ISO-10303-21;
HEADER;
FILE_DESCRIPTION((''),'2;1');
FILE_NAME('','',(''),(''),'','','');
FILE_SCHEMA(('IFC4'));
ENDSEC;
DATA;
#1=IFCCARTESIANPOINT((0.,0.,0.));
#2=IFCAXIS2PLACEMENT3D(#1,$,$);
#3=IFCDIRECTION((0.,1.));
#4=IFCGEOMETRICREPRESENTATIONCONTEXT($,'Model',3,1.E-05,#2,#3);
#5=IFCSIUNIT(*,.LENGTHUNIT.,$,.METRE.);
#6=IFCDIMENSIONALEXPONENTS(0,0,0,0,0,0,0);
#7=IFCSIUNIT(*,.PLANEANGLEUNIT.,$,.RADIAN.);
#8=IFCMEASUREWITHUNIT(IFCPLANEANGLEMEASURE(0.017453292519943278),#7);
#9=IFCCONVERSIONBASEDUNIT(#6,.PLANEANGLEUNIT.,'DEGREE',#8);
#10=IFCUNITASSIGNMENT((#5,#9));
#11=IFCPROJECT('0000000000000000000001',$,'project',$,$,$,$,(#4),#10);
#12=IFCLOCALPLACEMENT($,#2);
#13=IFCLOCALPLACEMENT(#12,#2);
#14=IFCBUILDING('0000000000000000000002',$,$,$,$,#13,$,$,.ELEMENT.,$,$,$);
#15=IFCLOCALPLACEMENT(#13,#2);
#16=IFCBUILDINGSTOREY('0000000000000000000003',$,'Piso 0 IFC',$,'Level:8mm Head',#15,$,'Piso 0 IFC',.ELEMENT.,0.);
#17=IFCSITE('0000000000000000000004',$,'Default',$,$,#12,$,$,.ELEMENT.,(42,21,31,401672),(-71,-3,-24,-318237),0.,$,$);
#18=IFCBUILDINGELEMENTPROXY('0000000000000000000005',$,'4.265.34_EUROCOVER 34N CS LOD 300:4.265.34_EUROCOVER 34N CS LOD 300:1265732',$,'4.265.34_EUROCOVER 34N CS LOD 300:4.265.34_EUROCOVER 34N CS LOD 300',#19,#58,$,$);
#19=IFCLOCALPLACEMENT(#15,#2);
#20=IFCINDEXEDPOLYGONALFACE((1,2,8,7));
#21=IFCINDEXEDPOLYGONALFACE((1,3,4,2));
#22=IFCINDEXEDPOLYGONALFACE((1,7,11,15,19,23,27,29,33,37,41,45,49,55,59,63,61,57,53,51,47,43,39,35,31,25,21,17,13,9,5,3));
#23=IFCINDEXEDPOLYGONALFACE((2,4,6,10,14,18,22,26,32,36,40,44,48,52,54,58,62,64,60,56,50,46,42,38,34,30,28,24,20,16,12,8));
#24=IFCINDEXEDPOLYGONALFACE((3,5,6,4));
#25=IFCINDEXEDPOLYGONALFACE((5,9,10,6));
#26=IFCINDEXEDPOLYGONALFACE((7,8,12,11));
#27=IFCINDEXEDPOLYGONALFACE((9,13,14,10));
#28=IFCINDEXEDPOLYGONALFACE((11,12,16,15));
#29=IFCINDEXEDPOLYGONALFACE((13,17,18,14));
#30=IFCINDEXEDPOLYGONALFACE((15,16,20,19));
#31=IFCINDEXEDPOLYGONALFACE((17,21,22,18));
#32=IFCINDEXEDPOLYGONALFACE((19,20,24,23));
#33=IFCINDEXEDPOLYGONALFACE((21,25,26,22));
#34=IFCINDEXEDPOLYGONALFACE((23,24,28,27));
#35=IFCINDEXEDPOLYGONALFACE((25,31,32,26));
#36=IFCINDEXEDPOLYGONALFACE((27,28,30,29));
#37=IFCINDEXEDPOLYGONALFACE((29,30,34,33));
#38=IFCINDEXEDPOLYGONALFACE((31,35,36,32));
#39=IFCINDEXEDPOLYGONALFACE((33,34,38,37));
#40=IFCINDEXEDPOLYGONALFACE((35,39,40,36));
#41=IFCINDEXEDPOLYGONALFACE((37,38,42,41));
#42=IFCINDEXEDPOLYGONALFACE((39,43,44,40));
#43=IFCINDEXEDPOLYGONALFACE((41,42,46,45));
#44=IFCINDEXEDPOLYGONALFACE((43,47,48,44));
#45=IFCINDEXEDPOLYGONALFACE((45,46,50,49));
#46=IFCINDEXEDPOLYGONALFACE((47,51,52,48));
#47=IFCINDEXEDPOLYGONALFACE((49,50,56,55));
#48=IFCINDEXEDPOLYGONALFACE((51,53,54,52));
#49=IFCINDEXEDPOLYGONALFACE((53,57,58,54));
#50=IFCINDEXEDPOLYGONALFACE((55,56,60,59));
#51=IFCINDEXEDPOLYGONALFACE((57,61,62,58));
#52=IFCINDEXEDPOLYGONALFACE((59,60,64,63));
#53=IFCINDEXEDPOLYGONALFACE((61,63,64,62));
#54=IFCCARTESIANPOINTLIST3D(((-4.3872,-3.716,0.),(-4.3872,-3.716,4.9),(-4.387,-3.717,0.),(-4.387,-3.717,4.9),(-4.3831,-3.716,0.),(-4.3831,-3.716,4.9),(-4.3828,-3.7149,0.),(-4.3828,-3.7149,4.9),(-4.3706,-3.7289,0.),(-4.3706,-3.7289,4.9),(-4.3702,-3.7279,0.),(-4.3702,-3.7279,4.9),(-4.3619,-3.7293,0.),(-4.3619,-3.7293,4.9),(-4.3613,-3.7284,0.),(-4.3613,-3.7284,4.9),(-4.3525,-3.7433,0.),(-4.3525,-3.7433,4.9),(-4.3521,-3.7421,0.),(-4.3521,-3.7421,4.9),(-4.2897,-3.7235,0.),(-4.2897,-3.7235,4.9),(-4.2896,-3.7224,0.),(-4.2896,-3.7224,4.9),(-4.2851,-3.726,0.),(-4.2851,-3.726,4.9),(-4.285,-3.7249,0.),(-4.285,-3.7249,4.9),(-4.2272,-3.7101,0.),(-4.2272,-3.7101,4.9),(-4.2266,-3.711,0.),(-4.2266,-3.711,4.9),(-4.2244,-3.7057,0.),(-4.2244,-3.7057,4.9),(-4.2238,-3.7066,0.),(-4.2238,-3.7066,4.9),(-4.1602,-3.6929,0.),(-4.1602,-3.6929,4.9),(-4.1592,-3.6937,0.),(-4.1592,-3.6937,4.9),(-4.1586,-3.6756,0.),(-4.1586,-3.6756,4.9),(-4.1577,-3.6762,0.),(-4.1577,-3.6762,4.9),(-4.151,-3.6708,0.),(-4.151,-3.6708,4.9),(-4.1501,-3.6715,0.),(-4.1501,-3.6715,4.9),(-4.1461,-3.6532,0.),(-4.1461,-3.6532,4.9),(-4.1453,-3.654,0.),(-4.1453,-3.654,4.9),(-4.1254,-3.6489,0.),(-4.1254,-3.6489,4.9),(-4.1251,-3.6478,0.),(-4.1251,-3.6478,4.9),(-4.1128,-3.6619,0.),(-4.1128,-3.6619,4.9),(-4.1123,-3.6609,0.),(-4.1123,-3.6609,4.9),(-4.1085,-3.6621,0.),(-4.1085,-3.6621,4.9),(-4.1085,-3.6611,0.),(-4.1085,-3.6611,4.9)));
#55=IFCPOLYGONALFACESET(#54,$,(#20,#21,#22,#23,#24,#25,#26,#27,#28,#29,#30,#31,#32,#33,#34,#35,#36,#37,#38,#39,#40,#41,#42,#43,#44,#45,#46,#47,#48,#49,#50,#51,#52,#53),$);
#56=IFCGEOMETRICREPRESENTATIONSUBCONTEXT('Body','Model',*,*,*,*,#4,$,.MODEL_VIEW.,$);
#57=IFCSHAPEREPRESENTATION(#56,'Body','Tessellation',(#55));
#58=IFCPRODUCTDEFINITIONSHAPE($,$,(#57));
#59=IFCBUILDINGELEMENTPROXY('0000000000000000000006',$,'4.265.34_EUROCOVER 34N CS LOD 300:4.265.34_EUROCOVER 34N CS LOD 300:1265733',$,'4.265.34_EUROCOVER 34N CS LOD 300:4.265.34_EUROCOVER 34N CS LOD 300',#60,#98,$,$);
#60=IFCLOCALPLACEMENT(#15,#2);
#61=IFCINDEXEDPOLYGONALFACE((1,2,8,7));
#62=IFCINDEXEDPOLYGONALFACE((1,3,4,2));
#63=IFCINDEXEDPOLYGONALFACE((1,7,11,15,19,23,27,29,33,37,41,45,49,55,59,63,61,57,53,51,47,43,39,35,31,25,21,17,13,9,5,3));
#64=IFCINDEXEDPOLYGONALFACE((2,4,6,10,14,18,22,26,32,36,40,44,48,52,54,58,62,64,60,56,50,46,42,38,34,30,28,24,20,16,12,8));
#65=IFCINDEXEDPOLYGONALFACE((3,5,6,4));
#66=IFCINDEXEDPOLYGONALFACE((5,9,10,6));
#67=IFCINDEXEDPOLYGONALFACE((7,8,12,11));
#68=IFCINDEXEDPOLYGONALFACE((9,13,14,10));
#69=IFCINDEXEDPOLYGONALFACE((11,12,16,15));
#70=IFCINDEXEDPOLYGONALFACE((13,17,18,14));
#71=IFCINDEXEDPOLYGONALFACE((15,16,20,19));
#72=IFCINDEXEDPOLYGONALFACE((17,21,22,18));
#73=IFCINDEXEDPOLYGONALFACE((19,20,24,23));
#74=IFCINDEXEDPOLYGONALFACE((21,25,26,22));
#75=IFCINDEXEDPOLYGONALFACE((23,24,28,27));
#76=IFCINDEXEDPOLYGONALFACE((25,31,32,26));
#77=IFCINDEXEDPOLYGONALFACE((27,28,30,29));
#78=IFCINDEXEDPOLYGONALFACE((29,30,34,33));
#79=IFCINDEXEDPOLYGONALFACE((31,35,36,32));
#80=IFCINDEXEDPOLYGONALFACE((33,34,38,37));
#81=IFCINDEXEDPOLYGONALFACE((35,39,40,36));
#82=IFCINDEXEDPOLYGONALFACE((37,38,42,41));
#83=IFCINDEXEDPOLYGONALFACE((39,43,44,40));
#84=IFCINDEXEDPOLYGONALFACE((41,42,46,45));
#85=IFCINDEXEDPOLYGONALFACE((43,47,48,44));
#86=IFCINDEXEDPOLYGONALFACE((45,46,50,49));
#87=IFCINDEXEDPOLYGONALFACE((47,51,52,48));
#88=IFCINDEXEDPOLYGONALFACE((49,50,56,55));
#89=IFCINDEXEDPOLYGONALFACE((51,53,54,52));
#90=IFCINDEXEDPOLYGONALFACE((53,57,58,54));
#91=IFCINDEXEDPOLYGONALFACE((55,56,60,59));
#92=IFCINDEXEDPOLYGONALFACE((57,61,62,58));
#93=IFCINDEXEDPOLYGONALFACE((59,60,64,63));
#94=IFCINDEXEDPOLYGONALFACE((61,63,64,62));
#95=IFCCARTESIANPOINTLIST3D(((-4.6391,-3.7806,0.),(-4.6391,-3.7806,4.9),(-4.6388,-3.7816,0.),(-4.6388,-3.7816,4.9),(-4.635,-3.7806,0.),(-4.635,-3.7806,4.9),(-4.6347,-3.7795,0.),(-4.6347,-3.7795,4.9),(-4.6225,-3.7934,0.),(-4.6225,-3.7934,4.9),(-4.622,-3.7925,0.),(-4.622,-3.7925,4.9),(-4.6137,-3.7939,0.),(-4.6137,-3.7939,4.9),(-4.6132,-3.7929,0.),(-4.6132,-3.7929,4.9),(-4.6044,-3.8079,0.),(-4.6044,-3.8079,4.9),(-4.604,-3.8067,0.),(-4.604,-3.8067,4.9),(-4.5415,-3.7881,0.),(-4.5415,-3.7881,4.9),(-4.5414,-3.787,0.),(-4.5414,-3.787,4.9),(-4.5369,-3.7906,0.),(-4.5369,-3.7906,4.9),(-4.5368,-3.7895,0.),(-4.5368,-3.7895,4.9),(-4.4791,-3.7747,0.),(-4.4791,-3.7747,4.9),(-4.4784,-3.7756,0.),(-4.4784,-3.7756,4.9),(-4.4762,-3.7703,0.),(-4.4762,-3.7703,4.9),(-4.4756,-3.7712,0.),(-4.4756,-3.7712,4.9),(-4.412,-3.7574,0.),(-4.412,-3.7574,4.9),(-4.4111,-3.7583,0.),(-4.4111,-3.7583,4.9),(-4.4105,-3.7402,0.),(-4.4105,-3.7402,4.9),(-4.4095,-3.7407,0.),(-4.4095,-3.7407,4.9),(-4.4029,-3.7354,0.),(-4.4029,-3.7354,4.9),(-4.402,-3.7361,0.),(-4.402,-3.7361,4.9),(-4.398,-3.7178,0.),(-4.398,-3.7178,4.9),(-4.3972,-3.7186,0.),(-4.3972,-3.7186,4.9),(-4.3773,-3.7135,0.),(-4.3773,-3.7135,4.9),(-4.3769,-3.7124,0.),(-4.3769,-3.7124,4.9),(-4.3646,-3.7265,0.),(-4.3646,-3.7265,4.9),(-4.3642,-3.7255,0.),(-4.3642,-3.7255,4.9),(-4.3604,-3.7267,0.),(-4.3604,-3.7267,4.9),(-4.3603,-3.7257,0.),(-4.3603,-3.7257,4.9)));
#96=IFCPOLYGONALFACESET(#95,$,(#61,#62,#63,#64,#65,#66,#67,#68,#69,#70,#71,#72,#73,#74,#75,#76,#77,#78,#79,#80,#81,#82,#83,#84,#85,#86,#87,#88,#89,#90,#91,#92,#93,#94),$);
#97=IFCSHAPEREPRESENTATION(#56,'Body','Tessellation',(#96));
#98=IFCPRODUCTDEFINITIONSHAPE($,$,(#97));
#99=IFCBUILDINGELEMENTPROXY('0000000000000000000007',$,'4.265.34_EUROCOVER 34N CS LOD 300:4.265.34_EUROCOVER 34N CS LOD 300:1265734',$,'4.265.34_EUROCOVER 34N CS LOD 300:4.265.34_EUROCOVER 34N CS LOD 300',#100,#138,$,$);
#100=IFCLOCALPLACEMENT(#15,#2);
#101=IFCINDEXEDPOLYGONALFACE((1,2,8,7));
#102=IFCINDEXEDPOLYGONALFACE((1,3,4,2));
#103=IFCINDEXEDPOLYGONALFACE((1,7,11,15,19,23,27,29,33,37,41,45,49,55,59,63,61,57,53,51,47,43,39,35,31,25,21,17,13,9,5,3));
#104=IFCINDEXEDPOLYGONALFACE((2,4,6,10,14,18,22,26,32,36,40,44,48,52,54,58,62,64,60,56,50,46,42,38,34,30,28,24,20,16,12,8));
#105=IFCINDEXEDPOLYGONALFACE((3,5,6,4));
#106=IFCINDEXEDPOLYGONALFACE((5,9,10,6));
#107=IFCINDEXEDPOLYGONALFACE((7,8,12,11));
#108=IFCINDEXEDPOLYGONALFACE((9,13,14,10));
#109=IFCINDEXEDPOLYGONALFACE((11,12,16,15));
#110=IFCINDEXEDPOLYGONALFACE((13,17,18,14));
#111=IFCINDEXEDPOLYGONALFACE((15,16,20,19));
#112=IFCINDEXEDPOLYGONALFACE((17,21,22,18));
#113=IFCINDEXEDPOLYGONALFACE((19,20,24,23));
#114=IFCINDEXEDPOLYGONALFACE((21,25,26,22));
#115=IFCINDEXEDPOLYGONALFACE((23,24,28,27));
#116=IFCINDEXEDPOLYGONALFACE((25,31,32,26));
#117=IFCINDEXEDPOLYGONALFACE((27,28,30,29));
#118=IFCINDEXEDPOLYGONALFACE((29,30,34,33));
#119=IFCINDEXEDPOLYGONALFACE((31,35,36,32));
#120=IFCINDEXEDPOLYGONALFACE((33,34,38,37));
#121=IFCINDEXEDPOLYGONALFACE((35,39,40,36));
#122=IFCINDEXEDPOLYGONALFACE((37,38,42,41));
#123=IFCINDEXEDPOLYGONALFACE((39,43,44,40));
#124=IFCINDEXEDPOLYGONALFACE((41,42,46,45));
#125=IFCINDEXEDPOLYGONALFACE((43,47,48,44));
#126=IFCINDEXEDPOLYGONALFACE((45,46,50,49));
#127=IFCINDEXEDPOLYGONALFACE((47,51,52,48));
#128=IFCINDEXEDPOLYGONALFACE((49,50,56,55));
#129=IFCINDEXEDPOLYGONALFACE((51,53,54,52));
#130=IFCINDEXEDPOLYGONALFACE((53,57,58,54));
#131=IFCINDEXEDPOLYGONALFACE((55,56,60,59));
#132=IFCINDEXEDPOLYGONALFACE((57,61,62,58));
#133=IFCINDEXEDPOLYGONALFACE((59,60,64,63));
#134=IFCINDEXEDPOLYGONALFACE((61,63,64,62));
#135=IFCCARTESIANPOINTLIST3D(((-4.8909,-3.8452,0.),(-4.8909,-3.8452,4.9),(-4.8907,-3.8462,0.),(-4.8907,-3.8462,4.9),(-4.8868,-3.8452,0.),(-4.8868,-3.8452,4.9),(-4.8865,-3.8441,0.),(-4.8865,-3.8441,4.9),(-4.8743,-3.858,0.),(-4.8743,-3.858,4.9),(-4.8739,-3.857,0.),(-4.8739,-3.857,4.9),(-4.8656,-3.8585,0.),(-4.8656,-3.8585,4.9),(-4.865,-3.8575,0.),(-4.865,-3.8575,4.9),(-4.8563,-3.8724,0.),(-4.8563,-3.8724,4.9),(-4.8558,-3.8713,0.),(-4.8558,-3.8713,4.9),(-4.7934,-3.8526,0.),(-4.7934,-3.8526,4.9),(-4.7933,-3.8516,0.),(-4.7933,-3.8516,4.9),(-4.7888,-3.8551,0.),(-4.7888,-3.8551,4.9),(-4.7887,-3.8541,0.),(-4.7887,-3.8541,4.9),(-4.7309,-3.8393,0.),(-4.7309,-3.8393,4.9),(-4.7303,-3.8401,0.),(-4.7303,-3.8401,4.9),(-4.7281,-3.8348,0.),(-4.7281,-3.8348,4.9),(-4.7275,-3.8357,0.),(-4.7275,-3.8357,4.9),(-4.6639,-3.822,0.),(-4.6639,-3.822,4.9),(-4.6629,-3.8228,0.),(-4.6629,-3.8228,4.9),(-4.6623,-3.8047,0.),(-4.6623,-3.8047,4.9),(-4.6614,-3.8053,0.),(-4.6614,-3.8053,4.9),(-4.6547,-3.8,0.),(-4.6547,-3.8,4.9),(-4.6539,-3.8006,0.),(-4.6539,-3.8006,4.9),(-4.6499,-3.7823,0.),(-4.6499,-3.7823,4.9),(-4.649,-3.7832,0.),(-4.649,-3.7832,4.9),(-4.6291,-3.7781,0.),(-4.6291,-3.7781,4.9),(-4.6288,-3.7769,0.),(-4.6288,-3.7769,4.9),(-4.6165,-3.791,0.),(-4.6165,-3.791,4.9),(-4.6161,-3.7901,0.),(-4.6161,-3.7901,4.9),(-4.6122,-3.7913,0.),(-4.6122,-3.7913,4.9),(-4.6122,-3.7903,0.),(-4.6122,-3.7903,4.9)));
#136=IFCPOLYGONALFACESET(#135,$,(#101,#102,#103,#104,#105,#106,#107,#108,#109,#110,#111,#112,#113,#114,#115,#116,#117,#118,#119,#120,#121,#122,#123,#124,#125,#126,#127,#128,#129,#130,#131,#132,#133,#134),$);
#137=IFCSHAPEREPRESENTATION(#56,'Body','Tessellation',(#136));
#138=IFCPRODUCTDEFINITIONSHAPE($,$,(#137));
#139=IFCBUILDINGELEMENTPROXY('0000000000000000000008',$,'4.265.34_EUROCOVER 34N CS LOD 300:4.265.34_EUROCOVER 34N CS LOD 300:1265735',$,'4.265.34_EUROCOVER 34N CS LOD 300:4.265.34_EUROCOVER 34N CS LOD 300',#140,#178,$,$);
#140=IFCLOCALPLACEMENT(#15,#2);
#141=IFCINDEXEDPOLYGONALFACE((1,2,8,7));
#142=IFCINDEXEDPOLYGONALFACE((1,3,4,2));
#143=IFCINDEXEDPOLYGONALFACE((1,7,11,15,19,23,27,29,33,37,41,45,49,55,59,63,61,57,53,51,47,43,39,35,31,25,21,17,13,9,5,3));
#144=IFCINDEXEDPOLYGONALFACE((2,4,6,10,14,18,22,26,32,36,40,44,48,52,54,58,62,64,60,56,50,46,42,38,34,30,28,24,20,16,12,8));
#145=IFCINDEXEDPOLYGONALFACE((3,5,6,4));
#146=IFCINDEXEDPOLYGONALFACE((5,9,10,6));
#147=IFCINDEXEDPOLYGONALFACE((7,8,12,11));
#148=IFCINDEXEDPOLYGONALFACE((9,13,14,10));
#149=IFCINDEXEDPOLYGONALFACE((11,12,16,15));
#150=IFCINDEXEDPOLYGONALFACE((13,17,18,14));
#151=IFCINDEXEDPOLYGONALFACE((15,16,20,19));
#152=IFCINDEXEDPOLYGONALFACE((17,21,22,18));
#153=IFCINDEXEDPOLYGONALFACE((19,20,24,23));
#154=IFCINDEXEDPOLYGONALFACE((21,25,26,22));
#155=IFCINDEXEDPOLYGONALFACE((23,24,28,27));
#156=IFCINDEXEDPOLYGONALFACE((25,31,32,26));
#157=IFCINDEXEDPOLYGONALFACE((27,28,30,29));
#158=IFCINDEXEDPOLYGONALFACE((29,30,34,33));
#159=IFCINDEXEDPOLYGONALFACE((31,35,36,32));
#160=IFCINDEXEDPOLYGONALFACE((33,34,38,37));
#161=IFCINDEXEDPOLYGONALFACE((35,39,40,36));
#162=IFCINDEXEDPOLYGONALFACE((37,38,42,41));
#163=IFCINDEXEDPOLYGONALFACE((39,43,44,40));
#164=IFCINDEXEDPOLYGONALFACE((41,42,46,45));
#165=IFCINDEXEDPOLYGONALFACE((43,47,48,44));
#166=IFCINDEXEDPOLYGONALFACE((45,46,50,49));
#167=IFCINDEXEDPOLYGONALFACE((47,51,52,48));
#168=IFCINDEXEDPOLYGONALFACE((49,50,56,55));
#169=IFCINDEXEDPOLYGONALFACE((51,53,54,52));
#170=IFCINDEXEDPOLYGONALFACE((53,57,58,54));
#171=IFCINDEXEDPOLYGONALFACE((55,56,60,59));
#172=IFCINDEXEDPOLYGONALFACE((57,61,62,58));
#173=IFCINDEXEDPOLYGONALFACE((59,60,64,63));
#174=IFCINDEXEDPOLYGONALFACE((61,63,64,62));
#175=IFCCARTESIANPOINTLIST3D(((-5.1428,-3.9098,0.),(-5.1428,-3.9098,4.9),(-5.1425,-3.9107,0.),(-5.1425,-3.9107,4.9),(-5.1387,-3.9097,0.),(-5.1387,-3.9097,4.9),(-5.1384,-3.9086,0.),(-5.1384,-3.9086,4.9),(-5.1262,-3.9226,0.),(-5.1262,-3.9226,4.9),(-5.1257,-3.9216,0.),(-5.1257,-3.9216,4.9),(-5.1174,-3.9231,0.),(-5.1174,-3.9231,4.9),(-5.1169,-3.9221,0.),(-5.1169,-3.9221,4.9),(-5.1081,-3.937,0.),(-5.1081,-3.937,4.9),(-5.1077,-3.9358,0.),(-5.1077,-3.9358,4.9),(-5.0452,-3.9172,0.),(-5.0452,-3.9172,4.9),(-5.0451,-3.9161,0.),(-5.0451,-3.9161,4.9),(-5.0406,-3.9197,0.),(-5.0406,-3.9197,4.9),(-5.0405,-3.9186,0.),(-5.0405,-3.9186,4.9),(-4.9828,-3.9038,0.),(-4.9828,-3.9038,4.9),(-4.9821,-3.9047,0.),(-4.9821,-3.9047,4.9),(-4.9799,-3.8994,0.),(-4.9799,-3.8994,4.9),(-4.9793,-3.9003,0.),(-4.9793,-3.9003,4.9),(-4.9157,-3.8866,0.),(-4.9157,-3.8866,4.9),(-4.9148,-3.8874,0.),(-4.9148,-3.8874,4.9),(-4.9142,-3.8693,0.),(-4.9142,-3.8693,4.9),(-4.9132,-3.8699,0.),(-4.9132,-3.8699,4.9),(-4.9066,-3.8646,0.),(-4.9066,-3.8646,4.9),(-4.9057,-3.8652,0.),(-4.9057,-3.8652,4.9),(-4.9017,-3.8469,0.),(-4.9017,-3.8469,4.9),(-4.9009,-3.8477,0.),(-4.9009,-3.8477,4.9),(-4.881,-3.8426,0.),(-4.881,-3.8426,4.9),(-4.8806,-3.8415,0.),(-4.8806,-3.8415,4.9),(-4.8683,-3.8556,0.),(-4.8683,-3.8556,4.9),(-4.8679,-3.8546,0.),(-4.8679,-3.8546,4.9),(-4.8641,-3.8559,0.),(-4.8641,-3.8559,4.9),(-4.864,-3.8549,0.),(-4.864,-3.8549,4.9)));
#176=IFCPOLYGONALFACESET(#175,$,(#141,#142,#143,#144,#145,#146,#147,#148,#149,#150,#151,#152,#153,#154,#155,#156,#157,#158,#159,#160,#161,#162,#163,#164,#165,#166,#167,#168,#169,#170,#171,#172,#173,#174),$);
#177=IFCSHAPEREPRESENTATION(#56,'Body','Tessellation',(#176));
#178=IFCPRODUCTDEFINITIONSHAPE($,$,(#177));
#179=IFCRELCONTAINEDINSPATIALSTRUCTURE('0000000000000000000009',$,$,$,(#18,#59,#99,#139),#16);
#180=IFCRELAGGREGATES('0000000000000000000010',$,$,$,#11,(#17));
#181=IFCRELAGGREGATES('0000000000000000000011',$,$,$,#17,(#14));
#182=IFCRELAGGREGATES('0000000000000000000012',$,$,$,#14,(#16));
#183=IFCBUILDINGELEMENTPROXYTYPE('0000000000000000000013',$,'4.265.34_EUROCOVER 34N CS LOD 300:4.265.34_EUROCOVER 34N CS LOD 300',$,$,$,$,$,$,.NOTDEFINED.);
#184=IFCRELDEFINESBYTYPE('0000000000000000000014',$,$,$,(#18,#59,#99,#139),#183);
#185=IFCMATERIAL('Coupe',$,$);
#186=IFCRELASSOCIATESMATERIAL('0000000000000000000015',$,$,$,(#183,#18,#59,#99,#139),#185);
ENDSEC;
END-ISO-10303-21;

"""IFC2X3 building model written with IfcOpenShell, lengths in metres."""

from ifc_helpers import new_model, entity, si_unit, converted_unit, direction, frame, origin, place, context, subcontext, project, spatial, polyline, outline, extrude, source, transform, mapped, material, type_object, type_shapes, element, save


model = new_model("IFC2X3")

# Units and contexts
model_context = context("Model", 3, precision=1e-05, world=origin(), true_north=direction((0.0, 1.0)))
body_context = subcontext(model_context, "Body", "Model", "MODEL_VIEW")
ifc_project = project(units=[si_unit("LENGTHUNIT", "METRE"), converted_unit("PLANEANGLEUNIT", "DEGREE", entity("IfcPlaneAngleMeasure", 0.017453292519943278), si_unit("PLANEANGLEUNIT", "RADIAN"), dimensions=[0, 0, 0, 0, 0, 0, 0])], contexts=[model_context])

# Site, building, storey
site_placement = place(None, origin())
site = spatial("IfcSite", under=ifc_project, at=site_placement, Name="Default", CompositionType="ELEMENT", RefLatitude=(42, 21, 31, 401672), RefLongitude=(-71, -3, -24, -318237), RefElevation=0.0)
building_placement = place(site_placement, origin())
building = spatial("IfcBuilding", under=site, at=building_placement, CompositionType="ELEMENT")
storey_placement = place(building_placement, origin())
storey = spatial("IfcBuildingStorey", under=building, at=storey_placement, Name="Piso 0 IFC", ObjectType="Level:8mm Head", LongName="Piso 0 IFC", CompositionType="ELEMENT", Elevation=0.0)

# Building element proxies
ifc_material_1 = material(Name="Coupe")
building_element_proxy_type = type_object("IfcBuildingElementProxyType", Name="4.265.34_EUROCOVER 34N CS LOD 300:4.265.34_EUROCOVER 34N CS LOD 300", PredefinedType="NOTDEFINED", material=ifc_material_1)
shared_shape_1 = source(origin(), body_context, "Body", "SweptSolid", [
    extrude(outline(polyline([(0.0449, 0.1162), (0.063, 0.1162), (0.0661, 0.1191), (0.0654, 0.1198), (0.0626, 0.1172), (0.0443, 0.1172), (0.0335, 0.0983), (0.0428, 0.0826), (0.0409, 0.0738), (0.0522, 0.0606), (0.0167, 0.0056), (0.0179, 0.0005), (-0.0117, -0.0512), (-0.0167, -0.0528), (-0.0462, -0.1114), (-0.0624, -0.1084), (-0.069, -0.1145), (-0.0871, -0.1145), (-0.0893, -0.1184), (-0.0885, -0.1189), (-0.0865, -0.1155), (-0.0686, -0.1155), (-0.0621, -0.1095), (-0.0456, -0.1125), (-0.016, -0.0536), (-0.0111, -0.0521), (0.0189, 0.0004), (0.0177, 0.0054), (0.0535, 0.0607), (0.0419, 0.074), (0.0438, 0.0827), (0.0347, 0.0983), (0.0449, 0.1162)])), frame((-0.0171, -0.0163, 0.0), z_axis=(0.0, 0.0, 1.0), x_axis=(-0.496574, 0.867994, 0.0)), (0.0, 0.0, 1.0), 4.9),
])
type_shapes(building_element_proxy_type, [shared_shape_1])
for number, where, z_axis, x_axis, name in (
    (1, (-4.2526, -3.7177, 0.0), (0.0, 0.0, 1.0), (-0.968666, -0.248367, 0.0), "4.265.34_EUROCOVER 34N CS LOD 300:4.265.34_EUROCOVER 34N CS LOD 300:1265732"),
    (2, (-4.5045, -3.7822, 0.0), (0.0, 0.0, 1.0), (-0.968666, -0.248367, 0.0), "4.265.34_EUROCOVER 34N CS LOD 300:4.265.34_EUROCOVER 34N CS LOD 300:1265733"),
    (3, (-4.7563, -3.8468, 0.0), (0.0, 0.0, 1.0), (-0.968666, -0.248367, 0.0), "4.265.34_EUROCOVER 34N CS LOD 300:4.265.34_EUROCOVER 34N CS LOD 300:1265734"),
    (4, (-5.0082, -3.9114, 0.0), (0.0, 0.0, 1.0), (-0.968666, -0.248367, 0.0), "4.265.34_EUROCOVER 34N CS LOD 300:4.265.34_EUROCOVER 34N CS LOD 300:1265735"),
):
    element("IfcBuildingElementProxy", number, at=place(storey_placement, frame(where, z_axis=z_axis, x_axis=x_axis)), inside=storey, type_object=building_element_proxy_type, material=ifc_material_1, Name=name, ObjectType="4.265.34_EUROCOVER 34N CS LOD 300:4.265.34_EUROCOVER 34N CS LOD 300", context=body_context, shape_type="MappedRepresentation", body=[
        mapped(shared_shape_1, transform((0.0, 0.0, 0.0), scale=1.0)),
    ])

save(model, "model.ifc")
